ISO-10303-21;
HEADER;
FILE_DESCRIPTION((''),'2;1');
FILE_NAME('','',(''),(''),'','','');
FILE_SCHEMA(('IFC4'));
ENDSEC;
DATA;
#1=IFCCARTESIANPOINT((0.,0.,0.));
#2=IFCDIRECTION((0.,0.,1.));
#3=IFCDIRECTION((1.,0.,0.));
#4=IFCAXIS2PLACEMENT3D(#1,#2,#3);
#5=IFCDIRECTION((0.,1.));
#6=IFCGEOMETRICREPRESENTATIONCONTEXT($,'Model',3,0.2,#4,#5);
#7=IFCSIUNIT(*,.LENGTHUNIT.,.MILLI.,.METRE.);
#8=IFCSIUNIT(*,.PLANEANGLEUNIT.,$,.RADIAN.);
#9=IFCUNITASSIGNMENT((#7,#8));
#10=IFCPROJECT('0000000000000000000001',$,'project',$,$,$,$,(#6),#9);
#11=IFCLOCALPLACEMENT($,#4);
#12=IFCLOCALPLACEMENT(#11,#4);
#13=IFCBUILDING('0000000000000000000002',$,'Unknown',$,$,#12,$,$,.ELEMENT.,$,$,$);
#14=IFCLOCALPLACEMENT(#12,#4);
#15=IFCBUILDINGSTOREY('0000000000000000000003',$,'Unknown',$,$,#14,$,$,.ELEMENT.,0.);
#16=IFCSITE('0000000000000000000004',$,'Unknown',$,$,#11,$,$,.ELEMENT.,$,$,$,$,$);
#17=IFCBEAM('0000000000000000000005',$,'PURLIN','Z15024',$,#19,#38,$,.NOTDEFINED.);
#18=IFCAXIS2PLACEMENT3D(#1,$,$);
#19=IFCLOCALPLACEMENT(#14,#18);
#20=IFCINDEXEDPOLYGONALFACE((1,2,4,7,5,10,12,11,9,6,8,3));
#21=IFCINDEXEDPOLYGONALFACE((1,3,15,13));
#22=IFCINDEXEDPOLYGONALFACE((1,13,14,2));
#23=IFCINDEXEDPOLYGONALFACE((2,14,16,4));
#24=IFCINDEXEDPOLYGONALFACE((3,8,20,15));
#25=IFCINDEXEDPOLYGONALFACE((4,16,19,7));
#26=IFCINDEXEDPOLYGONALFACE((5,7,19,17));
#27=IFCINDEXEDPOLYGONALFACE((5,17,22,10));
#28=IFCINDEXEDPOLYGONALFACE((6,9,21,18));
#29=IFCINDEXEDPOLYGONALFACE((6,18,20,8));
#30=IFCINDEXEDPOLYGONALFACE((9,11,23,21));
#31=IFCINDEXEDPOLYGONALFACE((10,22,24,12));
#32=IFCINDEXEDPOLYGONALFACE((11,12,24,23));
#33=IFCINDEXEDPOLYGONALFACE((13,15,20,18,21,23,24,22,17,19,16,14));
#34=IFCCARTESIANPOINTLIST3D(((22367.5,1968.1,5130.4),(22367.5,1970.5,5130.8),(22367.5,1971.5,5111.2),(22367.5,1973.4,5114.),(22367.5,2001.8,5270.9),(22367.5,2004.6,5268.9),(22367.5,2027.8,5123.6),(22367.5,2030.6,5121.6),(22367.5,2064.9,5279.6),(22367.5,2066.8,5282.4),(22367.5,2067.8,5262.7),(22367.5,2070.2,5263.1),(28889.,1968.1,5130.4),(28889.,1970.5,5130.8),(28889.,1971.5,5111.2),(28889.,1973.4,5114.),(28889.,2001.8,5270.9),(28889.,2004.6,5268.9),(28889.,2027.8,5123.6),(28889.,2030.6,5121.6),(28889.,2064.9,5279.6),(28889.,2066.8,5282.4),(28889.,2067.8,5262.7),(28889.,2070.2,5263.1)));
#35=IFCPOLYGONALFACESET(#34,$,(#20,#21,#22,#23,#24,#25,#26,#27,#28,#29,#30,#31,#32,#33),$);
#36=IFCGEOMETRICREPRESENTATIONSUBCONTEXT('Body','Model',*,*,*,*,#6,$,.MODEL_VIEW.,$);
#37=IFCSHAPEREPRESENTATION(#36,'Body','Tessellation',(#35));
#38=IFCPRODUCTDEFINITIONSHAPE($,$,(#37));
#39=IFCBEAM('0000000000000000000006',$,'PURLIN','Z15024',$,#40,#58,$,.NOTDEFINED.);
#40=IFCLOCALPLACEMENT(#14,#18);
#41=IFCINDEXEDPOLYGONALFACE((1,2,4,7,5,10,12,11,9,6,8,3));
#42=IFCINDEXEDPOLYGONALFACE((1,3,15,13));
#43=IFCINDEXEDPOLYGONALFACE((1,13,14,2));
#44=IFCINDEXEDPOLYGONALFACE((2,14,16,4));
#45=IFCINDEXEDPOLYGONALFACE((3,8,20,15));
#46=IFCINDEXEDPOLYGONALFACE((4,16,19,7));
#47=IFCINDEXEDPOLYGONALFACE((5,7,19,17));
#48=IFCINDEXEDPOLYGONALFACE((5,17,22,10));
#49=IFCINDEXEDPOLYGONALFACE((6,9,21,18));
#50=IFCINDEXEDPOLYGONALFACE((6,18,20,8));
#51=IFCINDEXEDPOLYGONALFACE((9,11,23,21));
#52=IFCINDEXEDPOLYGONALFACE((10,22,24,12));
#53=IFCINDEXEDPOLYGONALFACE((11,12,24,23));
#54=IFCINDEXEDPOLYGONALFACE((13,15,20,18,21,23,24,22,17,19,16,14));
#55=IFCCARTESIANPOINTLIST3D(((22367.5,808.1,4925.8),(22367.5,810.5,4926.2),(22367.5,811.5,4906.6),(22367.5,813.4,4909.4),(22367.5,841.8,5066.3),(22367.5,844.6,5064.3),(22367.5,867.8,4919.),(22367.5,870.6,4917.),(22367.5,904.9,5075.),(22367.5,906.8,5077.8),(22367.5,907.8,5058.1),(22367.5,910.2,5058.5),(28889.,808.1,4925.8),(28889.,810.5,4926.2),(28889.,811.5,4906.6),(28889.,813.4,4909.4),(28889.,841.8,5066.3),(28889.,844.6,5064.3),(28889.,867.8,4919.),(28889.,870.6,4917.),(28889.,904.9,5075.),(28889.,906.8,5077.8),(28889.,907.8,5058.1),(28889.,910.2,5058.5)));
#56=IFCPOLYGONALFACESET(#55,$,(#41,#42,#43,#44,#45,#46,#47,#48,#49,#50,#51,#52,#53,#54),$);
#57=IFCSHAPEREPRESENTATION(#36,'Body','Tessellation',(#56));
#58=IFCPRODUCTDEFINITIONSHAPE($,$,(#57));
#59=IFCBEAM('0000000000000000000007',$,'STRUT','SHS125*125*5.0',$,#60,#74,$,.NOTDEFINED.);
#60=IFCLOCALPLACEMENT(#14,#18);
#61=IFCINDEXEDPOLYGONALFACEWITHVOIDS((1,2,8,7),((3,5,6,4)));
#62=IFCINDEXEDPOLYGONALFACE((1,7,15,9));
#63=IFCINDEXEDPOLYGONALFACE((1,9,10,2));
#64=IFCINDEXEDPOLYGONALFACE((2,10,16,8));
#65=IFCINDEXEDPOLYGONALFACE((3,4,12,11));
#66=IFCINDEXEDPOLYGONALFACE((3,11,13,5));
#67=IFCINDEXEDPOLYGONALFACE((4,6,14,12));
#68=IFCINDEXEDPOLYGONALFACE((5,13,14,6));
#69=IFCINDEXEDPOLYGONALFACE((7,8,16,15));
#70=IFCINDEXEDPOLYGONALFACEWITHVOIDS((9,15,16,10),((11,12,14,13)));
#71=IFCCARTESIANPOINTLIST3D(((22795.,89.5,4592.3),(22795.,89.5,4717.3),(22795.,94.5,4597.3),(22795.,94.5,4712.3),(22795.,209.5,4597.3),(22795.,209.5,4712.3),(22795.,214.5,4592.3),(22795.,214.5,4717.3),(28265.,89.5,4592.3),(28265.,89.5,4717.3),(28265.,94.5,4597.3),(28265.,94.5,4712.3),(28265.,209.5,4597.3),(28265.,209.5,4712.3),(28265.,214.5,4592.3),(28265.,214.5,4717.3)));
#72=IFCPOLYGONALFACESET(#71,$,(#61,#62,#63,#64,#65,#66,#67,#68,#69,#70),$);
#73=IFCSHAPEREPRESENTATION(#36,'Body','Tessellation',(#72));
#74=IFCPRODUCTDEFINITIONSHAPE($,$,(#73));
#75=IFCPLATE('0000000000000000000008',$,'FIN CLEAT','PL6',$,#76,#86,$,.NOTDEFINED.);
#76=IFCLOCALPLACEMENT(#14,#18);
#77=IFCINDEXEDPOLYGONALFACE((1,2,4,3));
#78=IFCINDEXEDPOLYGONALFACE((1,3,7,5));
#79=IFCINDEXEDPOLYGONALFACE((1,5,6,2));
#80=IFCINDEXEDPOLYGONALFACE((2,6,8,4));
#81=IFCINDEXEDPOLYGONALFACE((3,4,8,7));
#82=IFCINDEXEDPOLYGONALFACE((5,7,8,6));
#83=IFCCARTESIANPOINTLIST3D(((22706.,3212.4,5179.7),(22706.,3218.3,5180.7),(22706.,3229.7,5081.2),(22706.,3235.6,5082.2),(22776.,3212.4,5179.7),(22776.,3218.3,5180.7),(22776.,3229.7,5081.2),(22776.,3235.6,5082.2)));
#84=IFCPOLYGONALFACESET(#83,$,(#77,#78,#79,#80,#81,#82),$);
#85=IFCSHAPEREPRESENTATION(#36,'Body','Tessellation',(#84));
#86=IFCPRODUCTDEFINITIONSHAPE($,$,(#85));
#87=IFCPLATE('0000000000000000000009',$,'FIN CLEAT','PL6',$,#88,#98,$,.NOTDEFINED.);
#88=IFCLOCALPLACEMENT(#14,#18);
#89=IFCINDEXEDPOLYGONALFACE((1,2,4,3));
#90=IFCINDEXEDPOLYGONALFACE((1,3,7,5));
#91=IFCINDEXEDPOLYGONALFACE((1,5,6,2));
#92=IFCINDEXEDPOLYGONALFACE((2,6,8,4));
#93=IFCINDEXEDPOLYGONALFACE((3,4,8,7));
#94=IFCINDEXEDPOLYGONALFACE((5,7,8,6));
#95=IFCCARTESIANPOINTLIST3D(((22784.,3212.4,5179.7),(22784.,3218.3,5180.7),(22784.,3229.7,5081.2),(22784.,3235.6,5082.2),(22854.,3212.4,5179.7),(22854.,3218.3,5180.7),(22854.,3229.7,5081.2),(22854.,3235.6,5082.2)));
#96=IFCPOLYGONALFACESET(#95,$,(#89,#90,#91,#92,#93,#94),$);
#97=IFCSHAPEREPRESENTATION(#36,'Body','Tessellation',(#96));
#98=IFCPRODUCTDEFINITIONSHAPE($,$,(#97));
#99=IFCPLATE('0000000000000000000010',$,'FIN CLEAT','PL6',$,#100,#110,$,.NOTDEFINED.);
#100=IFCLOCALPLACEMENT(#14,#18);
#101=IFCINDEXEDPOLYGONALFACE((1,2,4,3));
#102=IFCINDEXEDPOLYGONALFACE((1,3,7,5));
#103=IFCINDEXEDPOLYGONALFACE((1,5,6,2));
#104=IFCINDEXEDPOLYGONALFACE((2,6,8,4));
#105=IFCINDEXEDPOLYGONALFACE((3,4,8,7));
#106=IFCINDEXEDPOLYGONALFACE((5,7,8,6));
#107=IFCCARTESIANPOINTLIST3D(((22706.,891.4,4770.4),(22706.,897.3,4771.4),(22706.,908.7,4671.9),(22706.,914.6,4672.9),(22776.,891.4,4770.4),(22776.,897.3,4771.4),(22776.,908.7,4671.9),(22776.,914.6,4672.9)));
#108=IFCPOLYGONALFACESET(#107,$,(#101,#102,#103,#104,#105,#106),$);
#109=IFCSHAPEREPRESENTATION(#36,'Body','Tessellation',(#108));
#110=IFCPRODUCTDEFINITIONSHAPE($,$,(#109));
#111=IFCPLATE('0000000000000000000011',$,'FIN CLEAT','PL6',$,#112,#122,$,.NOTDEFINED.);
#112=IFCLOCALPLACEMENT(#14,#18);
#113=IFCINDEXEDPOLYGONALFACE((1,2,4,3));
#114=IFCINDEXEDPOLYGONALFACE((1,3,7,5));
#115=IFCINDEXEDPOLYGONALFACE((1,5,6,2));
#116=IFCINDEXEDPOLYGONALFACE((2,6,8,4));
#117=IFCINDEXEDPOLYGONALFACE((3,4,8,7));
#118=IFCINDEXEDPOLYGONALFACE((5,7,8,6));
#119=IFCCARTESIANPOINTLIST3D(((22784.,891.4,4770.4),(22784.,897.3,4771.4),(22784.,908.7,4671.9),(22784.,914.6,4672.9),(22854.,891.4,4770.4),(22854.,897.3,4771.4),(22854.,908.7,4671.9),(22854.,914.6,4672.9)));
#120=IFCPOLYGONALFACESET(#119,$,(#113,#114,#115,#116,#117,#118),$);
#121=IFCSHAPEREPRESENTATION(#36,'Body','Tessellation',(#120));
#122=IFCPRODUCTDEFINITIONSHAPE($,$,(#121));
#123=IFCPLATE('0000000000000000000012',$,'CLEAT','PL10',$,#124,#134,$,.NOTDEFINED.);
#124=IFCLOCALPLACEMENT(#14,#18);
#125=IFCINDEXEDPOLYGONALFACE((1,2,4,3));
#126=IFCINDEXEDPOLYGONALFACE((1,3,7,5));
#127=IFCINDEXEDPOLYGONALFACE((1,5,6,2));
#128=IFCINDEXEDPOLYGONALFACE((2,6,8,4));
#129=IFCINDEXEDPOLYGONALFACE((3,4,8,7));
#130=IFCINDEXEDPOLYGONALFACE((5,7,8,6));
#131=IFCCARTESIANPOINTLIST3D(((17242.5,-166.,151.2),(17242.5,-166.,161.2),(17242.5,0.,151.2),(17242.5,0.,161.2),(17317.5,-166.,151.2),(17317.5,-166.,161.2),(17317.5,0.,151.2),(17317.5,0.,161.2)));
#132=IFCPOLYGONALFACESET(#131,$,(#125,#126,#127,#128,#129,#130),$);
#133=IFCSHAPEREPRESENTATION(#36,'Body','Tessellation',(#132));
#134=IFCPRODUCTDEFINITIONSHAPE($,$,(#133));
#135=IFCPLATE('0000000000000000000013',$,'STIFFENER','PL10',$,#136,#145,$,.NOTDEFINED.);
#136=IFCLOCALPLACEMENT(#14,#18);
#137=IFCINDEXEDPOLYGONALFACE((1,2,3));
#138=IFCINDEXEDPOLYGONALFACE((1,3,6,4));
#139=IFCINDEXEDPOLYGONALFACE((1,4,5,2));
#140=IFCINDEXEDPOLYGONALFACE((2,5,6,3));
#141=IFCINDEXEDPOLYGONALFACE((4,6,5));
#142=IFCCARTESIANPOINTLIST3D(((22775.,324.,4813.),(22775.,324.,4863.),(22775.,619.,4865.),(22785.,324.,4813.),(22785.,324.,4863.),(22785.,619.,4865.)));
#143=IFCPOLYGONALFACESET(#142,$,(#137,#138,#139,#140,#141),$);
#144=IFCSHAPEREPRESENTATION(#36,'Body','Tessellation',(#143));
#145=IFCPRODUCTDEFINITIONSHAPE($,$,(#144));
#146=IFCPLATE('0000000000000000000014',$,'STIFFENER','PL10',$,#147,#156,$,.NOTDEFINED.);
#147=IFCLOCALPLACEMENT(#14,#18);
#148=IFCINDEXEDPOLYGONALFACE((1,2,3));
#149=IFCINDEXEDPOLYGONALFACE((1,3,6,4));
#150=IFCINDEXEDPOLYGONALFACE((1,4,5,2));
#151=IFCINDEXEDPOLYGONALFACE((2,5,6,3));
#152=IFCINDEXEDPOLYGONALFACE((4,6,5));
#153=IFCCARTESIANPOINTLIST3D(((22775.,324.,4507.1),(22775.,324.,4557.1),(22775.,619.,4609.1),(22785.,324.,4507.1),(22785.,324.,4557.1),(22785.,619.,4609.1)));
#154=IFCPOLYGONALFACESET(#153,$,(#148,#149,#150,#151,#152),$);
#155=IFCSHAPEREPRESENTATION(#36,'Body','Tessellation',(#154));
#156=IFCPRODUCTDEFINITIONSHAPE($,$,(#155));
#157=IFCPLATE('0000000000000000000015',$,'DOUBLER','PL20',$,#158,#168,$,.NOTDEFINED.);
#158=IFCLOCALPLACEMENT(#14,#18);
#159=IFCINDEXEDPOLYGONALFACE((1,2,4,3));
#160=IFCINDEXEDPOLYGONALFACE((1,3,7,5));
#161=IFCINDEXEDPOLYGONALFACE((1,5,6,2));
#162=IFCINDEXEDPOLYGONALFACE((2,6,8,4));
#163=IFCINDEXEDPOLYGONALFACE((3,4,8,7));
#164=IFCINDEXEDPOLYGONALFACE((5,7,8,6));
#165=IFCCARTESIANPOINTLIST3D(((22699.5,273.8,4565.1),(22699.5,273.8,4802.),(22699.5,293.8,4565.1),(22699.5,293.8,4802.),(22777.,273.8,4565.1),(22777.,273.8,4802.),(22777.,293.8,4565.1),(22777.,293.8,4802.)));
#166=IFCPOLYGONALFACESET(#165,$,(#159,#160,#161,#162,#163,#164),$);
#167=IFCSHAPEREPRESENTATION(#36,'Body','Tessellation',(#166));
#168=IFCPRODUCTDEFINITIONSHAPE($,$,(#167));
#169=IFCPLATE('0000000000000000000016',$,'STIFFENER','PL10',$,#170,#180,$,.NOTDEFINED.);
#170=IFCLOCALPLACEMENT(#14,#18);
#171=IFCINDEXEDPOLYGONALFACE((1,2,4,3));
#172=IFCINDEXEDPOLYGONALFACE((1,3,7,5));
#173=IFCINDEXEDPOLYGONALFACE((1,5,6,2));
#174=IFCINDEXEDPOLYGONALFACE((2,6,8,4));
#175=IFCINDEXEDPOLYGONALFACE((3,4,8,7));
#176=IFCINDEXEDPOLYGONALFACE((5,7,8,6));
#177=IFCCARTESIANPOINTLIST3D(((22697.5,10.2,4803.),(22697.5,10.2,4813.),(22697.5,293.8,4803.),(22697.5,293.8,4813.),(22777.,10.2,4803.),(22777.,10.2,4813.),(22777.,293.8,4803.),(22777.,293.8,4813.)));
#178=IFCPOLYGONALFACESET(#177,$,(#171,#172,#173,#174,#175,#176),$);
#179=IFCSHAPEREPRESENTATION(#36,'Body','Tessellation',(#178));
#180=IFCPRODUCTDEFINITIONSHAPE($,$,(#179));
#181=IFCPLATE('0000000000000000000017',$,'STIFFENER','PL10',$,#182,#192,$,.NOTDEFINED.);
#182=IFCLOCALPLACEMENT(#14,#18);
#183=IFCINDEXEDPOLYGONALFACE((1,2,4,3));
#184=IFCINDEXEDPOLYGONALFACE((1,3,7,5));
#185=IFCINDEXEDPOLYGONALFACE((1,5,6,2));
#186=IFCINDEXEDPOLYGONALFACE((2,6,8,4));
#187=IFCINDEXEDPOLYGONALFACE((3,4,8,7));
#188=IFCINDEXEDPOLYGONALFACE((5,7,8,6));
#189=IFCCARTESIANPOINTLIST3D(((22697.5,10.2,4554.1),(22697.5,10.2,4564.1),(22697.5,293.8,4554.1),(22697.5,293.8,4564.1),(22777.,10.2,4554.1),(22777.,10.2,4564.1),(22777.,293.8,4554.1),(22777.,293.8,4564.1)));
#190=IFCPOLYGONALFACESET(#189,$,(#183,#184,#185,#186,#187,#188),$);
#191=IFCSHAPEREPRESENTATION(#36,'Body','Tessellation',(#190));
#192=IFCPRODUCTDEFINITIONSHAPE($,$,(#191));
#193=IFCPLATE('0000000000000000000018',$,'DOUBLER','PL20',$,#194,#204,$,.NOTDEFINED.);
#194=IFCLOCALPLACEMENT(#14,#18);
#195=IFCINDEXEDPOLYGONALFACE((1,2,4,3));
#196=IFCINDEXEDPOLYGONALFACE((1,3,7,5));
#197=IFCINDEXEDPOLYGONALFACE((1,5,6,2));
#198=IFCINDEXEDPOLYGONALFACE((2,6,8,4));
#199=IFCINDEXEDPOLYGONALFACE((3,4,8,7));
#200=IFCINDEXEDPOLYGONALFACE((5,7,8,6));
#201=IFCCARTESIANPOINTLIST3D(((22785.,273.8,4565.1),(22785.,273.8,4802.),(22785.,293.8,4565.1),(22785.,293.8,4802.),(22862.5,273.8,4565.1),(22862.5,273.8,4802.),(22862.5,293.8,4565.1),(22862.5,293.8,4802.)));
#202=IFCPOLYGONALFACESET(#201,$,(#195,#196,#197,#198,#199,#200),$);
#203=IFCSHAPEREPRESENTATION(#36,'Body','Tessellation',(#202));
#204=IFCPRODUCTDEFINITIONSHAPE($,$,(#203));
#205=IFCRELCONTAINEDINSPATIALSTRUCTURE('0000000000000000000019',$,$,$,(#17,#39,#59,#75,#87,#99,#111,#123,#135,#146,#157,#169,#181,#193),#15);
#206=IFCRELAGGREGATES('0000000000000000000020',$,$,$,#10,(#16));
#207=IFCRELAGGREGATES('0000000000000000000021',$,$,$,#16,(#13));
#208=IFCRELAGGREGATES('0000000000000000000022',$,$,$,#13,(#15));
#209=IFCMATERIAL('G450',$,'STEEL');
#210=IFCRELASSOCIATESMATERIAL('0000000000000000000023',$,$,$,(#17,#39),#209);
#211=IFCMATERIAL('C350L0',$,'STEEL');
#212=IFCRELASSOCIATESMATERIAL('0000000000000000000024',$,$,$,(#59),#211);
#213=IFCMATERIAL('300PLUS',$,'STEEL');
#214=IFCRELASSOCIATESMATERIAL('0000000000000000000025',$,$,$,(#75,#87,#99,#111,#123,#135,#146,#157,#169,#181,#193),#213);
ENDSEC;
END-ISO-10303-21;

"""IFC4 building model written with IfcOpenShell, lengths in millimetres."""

from ifc_helpers import new_model, si_unit, direction, frame, origin_with_axes, place, context, subcontext, project, spatial, line, indexed_curve, outline, extrude, material, element, save


model = new_model("IFC4")

# Units and contexts
model_context = context("Model", 3, precision=0.2, world=origin_with_axes(), true_north=direction((0.0, 1.0)))
body_context = subcontext(model_context, "Body", "Model", "MODEL_VIEW")
ifc_project = project(units=[si_unit("LENGTHUNIT", "METRE", prefix="MILLI"), si_unit("PLANEANGLEUNIT", "RADIAN")], contexts=[model_context])

# Site, building, storey
site_placement = place(None, origin_with_axes())
site = spatial("IfcSite", under=ifc_project, at=site_placement, Name="Unknown", CompositionType="ELEMENT")
building_placement = place(site_placement, origin_with_axes())
building = spatial("IfcBuilding", under=site, at=building_placement, Name="Unknown", CompositionType="ELEMENT")
storey_placement = place(building_placement, origin_with_axes())
storey = spatial("IfcBuildingStorey", under=building, at=storey_placement, Name="Unknown", CompositionType="ELEMENT", Elevation=0.0)

# Shared definitions
ifc_material_1 = material(Name="300PLUS", Category="STEEL")

# Beams
ifc_material_2 = material(Name="G450", Category="STEEL")
for number, where, z_axis, x_axis, name in (
    (1, (22367.5, 2016.2, 5196.3), (0.0, -0.984808, -0.173648), (1.0, 0.0, 0.0), "PURLIN"),
    (2, (22367.5, 856.2, 4991.7), (0.0, -0.984808, -0.173648), (1.0, 0.0, 0.0), "PURLIN"),
):
    element("IfcBeam", number, at=place(storey_placement, frame(where, z_axis=z_axis, x_axis=x_axis)), inside=storey, material=ifc_material_2, Name=name, Description="Z15024", PredefinedType="NOTDEFINED", context=body_context, shape_type="SolidModel", body=[
        extrude(outline(indexed_curve([(58.8, -76.0), (58.8, -56.5), (56.4, -56.5), (56.4, -73.6), (1.2, -73.6), (1.2, 76.0), (-64.8, 76.0), (-64.8, 56.5), (-62.4, 56.5), (-62.4, 73.6), (-1.2, 73.6), (-1.2, -76.0)], segments=[line(1, 2, 3, 4, 5, 6, 7, 8, 9, 10, 11, 12, 1)])), frame((0.0, 0.0, 0.0), z_axis=(-1.0, 0.0, 0.0), x_axis=(0.0, 0.0, 1.0)), (0.0, 0.0, -1.0), 6521.5),
    ])
ifc_material_3 = material(Name="C350L0", Category="STEEL")
beam_1_placement = place(storey_placement, frame((22795.0, 152.0, 4654.8), z_axis=(0.0, 0.0, 1.0), x_axis=(1.0, 0.0, 0.0)))
element("IfcBeam", 3, at=beam_1_placement, inside=storey, material=ifc_material_3, Name="STRUT", Description="SHS125*125*5.0", PredefinedType="NOTDEFINED", context=body_context, shape_type="SolidModel", body=[
    extrude(outline(indexed_curve([(-62.5, -62.5), (62.5, -62.5), (62.5, 62.5), (-62.5, 62.5)], segments=[line(1, 2, 3, 4, 1)]), holes=[indexed_curve([(-57.5, -57.5), (-57.5, 57.5), (57.5, 57.5), (57.5, -57.5)], segments=[line(1, 2, 3, 4, 1)])]), frame((0.0, 0.0, 0.0), z_axis=(-1.0, 0.0, 0.0), x_axis=(0.0, 0.0, 1.0)), (0.0, 0.0, -1.0), 5470.0),
])

# Plates
for number, where, z_axis, x_axis, name in (
    (4, (22706.0, 3215.4, 5180.2), (0.0, 0.984924, 0.172987), (1.0, 0.0, 0.0), "FIN CLEAT"),
    (5, (22784.0, 3215.4, 5180.2), (0.0, 0.984924, 0.172987), (1.0, 0.0, 0.0), "FIN CLEAT"),
    (6, (22706.0, 894.4, 4770.9), (0.0, 0.984924, 0.172987), (1.0, 0.0, 0.0), "FIN CLEAT"),
    (7, (22784.0, 894.4, 4770.9), (0.0, 0.984924, 0.172987), (1.0, 0.0, 0.0), "FIN CLEAT"),
):
    element("IfcPlate", number, at=place(storey_placement, frame(where, z_axis=z_axis, x_axis=x_axis)), inside=storey, material=ifc_material_1, Name=name, Description="PL6", PredefinedType="NOTDEFINED", context=body_context, shape_type="SolidModel", body=[
        extrude(outline(indexed_curve([(0.0, 0.0), (70.0, 0.0), (70.0, 100.0), (0.0, 100.0)], segments=[line(1, 2, 3, 4, 1)])), frame((0.0, 0.0, 3.0), z_axis=(0.0, 0.0, 1.0), x_axis=(1.0, 0.0, 0.0)), (0.0, 0.0, -1.0), 6.0),
    ])
plate_1_placement = place(storey_placement, frame((17317.5, 0.0, 156.2), z_axis=(0.0, 0.0, 1.0), x_axis=(-1.0, 0.0, 0.0)))
element("IfcPlate", 8, at=plate_1_placement, inside=storey, material=ifc_material_1, Name="CLEAT", Description="PL10", PredefinedType="NOTDEFINED", context=body_context, shape_type="SolidModel", body=[
    extrude(outline(indexed_curve([(0.0, 0.0), (75.0, 0.0), (75.0, 166.0), (0.0, 166.0)], segments=[line(1, 2, 3, 4, 1)])), frame((0.0, 0.0, 5.0), z_axis=(0.0, 0.0, 1.0), x_axis=(1.0, 0.0, 0.0)), (0.0, 0.0, -1.0), 10.0),
])
plate_2_placement = place(storey_placement, frame((22780.0, 619.0, 4865.0), z_axis=(1.0, 0.0, 0.0), x_axis=(0.0, -0.999977, -0.00678)))
element("IfcPlate", 9, at=plate_2_placement, inside=storey, material=ifc_material_1, Name="STIFFENER", Description="PL10", PredefinedType="NOTDEFINED", context=body_context, shape_type="SolidModel", body=[
    extrude(outline(indexed_curve([(0.0, 0.0), (295.0, 0.0), (295.3, 50.0)], segments=[line(1, 2, 3, 1)])), frame((0.0, 0.0, 5.0), z_axis=(0.0, 0.0, 1.0), x_axis=(1.0, 0.0, 0.0)), (0.0, 0.0, -1.0), 10.0),
])
plate_3_placement = place(storey_placement, frame((22780.0, 619.0, 4609.1), z_axis=(1.0, 0.0, 0.0), x_axis=(0.0, -0.984817, -0.173595)))
element("IfcPlate", 10, at=plate_3_placement, inside=storey, material=ifc_material_1, Name="STIFFENER", Description="PL10", PredefinedType="NOTDEFINED", context=body_context, shape_type="SolidModel", body=[
    extrude(outline(indexed_curve([(0.0, 0.0), (299.5, 0.0), (308.2, 49.2)], segments=[line(1, 2, 3, 1)])), frame((0.0, 0.0, 5.0), z_axis=(0.0, 0.0, 1.0), x_axis=(1.0, 0.0, 0.0)), (0.0, 0.0, -1.0), 10.0),
])
plate_4_placement = place(storey_placement, frame((22699.5, 283.8, 4565.1), z_axis=(0.0, -1.0, 0.0), x_axis=(1.0, 0.0, 0.0)))
element("IfcPlate", 11, at=plate_4_placement, inside=storey, material=ifc_material_1, Name="DOUBLER", Description="PL20", PredefinedType="NOTDEFINED", context=body_context, shape_type="SolidModel", body=[
    extrude(outline(indexed_curve([(0.0, 0.0), (77.5, 0.0), (77.5, 236.9), (0.0, 236.9)], segments=[line(1, 2, 3, 4, 1)])), frame((0.0, 0.0, 10.0), z_axis=(0.0, 0.0, 1.0), x_axis=(1.0, 0.0, 0.0)), (0.0, 0.0, -1.0), 20.0),
])
for number, where, z_axis, x_axis, name in (
    (12, (22697.5, 10.2, 4808.0), (0.0, 0.0, 1.0), (1.0, 0.0, 0.0), "STIFFENER"),
    (13, (22697.5, 10.2, 4559.1), (0.0, 0.0, 1.0), (1.0, 0.0, 0.0), "STIFFENER"),
):
    element("IfcPlate", number, at=place(storey_placement, frame(where, z_axis=z_axis, x_axis=x_axis)), inside=storey, material=ifc_material_1, Name=name, Description="PL10", PredefinedType="NOTDEFINED", context=body_context, shape_type="SolidModel", body=[
        extrude(outline(indexed_curve([(0.0, 0.0), (79.5, 0.0), (79.5, 283.6), (0.0, 283.6)], segments=[line(1, 2, 3, 4, 1)])), frame((0.0, 0.0, 5.0), z_axis=(0.0, 0.0, 1.0), x_axis=(1.0, 0.0, 0.0)), (0.0, 0.0, -1.0), 10.0),
    ])
plate_5_placement = place(storey_placement, frame((22785.0, 283.8, 4565.1), z_axis=(0.0, -1.0, 0.0), x_axis=(1.0, 0.0, 0.0)))
element("IfcPlate", 14, at=plate_5_placement, inside=storey, material=ifc_material_1, Name="DOUBLER", Description="PL20", PredefinedType="NOTDEFINED", context=body_context, shape_type="SolidModel", body=[
    extrude(outline(indexed_curve([(0.0, 0.0), (77.5, 0.0), (77.5, 236.9), (0.0, 236.9)], segments=[line(1, 2, 3, 4, 1)])), frame((0.0, 0.0, 10.0), z_axis=(0.0, 0.0, 1.0), x_axis=(1.0, 0.0, 0.0)), (0.0, 0.0, -1.0), 20.0),
])

save(model, "model.ifc")
